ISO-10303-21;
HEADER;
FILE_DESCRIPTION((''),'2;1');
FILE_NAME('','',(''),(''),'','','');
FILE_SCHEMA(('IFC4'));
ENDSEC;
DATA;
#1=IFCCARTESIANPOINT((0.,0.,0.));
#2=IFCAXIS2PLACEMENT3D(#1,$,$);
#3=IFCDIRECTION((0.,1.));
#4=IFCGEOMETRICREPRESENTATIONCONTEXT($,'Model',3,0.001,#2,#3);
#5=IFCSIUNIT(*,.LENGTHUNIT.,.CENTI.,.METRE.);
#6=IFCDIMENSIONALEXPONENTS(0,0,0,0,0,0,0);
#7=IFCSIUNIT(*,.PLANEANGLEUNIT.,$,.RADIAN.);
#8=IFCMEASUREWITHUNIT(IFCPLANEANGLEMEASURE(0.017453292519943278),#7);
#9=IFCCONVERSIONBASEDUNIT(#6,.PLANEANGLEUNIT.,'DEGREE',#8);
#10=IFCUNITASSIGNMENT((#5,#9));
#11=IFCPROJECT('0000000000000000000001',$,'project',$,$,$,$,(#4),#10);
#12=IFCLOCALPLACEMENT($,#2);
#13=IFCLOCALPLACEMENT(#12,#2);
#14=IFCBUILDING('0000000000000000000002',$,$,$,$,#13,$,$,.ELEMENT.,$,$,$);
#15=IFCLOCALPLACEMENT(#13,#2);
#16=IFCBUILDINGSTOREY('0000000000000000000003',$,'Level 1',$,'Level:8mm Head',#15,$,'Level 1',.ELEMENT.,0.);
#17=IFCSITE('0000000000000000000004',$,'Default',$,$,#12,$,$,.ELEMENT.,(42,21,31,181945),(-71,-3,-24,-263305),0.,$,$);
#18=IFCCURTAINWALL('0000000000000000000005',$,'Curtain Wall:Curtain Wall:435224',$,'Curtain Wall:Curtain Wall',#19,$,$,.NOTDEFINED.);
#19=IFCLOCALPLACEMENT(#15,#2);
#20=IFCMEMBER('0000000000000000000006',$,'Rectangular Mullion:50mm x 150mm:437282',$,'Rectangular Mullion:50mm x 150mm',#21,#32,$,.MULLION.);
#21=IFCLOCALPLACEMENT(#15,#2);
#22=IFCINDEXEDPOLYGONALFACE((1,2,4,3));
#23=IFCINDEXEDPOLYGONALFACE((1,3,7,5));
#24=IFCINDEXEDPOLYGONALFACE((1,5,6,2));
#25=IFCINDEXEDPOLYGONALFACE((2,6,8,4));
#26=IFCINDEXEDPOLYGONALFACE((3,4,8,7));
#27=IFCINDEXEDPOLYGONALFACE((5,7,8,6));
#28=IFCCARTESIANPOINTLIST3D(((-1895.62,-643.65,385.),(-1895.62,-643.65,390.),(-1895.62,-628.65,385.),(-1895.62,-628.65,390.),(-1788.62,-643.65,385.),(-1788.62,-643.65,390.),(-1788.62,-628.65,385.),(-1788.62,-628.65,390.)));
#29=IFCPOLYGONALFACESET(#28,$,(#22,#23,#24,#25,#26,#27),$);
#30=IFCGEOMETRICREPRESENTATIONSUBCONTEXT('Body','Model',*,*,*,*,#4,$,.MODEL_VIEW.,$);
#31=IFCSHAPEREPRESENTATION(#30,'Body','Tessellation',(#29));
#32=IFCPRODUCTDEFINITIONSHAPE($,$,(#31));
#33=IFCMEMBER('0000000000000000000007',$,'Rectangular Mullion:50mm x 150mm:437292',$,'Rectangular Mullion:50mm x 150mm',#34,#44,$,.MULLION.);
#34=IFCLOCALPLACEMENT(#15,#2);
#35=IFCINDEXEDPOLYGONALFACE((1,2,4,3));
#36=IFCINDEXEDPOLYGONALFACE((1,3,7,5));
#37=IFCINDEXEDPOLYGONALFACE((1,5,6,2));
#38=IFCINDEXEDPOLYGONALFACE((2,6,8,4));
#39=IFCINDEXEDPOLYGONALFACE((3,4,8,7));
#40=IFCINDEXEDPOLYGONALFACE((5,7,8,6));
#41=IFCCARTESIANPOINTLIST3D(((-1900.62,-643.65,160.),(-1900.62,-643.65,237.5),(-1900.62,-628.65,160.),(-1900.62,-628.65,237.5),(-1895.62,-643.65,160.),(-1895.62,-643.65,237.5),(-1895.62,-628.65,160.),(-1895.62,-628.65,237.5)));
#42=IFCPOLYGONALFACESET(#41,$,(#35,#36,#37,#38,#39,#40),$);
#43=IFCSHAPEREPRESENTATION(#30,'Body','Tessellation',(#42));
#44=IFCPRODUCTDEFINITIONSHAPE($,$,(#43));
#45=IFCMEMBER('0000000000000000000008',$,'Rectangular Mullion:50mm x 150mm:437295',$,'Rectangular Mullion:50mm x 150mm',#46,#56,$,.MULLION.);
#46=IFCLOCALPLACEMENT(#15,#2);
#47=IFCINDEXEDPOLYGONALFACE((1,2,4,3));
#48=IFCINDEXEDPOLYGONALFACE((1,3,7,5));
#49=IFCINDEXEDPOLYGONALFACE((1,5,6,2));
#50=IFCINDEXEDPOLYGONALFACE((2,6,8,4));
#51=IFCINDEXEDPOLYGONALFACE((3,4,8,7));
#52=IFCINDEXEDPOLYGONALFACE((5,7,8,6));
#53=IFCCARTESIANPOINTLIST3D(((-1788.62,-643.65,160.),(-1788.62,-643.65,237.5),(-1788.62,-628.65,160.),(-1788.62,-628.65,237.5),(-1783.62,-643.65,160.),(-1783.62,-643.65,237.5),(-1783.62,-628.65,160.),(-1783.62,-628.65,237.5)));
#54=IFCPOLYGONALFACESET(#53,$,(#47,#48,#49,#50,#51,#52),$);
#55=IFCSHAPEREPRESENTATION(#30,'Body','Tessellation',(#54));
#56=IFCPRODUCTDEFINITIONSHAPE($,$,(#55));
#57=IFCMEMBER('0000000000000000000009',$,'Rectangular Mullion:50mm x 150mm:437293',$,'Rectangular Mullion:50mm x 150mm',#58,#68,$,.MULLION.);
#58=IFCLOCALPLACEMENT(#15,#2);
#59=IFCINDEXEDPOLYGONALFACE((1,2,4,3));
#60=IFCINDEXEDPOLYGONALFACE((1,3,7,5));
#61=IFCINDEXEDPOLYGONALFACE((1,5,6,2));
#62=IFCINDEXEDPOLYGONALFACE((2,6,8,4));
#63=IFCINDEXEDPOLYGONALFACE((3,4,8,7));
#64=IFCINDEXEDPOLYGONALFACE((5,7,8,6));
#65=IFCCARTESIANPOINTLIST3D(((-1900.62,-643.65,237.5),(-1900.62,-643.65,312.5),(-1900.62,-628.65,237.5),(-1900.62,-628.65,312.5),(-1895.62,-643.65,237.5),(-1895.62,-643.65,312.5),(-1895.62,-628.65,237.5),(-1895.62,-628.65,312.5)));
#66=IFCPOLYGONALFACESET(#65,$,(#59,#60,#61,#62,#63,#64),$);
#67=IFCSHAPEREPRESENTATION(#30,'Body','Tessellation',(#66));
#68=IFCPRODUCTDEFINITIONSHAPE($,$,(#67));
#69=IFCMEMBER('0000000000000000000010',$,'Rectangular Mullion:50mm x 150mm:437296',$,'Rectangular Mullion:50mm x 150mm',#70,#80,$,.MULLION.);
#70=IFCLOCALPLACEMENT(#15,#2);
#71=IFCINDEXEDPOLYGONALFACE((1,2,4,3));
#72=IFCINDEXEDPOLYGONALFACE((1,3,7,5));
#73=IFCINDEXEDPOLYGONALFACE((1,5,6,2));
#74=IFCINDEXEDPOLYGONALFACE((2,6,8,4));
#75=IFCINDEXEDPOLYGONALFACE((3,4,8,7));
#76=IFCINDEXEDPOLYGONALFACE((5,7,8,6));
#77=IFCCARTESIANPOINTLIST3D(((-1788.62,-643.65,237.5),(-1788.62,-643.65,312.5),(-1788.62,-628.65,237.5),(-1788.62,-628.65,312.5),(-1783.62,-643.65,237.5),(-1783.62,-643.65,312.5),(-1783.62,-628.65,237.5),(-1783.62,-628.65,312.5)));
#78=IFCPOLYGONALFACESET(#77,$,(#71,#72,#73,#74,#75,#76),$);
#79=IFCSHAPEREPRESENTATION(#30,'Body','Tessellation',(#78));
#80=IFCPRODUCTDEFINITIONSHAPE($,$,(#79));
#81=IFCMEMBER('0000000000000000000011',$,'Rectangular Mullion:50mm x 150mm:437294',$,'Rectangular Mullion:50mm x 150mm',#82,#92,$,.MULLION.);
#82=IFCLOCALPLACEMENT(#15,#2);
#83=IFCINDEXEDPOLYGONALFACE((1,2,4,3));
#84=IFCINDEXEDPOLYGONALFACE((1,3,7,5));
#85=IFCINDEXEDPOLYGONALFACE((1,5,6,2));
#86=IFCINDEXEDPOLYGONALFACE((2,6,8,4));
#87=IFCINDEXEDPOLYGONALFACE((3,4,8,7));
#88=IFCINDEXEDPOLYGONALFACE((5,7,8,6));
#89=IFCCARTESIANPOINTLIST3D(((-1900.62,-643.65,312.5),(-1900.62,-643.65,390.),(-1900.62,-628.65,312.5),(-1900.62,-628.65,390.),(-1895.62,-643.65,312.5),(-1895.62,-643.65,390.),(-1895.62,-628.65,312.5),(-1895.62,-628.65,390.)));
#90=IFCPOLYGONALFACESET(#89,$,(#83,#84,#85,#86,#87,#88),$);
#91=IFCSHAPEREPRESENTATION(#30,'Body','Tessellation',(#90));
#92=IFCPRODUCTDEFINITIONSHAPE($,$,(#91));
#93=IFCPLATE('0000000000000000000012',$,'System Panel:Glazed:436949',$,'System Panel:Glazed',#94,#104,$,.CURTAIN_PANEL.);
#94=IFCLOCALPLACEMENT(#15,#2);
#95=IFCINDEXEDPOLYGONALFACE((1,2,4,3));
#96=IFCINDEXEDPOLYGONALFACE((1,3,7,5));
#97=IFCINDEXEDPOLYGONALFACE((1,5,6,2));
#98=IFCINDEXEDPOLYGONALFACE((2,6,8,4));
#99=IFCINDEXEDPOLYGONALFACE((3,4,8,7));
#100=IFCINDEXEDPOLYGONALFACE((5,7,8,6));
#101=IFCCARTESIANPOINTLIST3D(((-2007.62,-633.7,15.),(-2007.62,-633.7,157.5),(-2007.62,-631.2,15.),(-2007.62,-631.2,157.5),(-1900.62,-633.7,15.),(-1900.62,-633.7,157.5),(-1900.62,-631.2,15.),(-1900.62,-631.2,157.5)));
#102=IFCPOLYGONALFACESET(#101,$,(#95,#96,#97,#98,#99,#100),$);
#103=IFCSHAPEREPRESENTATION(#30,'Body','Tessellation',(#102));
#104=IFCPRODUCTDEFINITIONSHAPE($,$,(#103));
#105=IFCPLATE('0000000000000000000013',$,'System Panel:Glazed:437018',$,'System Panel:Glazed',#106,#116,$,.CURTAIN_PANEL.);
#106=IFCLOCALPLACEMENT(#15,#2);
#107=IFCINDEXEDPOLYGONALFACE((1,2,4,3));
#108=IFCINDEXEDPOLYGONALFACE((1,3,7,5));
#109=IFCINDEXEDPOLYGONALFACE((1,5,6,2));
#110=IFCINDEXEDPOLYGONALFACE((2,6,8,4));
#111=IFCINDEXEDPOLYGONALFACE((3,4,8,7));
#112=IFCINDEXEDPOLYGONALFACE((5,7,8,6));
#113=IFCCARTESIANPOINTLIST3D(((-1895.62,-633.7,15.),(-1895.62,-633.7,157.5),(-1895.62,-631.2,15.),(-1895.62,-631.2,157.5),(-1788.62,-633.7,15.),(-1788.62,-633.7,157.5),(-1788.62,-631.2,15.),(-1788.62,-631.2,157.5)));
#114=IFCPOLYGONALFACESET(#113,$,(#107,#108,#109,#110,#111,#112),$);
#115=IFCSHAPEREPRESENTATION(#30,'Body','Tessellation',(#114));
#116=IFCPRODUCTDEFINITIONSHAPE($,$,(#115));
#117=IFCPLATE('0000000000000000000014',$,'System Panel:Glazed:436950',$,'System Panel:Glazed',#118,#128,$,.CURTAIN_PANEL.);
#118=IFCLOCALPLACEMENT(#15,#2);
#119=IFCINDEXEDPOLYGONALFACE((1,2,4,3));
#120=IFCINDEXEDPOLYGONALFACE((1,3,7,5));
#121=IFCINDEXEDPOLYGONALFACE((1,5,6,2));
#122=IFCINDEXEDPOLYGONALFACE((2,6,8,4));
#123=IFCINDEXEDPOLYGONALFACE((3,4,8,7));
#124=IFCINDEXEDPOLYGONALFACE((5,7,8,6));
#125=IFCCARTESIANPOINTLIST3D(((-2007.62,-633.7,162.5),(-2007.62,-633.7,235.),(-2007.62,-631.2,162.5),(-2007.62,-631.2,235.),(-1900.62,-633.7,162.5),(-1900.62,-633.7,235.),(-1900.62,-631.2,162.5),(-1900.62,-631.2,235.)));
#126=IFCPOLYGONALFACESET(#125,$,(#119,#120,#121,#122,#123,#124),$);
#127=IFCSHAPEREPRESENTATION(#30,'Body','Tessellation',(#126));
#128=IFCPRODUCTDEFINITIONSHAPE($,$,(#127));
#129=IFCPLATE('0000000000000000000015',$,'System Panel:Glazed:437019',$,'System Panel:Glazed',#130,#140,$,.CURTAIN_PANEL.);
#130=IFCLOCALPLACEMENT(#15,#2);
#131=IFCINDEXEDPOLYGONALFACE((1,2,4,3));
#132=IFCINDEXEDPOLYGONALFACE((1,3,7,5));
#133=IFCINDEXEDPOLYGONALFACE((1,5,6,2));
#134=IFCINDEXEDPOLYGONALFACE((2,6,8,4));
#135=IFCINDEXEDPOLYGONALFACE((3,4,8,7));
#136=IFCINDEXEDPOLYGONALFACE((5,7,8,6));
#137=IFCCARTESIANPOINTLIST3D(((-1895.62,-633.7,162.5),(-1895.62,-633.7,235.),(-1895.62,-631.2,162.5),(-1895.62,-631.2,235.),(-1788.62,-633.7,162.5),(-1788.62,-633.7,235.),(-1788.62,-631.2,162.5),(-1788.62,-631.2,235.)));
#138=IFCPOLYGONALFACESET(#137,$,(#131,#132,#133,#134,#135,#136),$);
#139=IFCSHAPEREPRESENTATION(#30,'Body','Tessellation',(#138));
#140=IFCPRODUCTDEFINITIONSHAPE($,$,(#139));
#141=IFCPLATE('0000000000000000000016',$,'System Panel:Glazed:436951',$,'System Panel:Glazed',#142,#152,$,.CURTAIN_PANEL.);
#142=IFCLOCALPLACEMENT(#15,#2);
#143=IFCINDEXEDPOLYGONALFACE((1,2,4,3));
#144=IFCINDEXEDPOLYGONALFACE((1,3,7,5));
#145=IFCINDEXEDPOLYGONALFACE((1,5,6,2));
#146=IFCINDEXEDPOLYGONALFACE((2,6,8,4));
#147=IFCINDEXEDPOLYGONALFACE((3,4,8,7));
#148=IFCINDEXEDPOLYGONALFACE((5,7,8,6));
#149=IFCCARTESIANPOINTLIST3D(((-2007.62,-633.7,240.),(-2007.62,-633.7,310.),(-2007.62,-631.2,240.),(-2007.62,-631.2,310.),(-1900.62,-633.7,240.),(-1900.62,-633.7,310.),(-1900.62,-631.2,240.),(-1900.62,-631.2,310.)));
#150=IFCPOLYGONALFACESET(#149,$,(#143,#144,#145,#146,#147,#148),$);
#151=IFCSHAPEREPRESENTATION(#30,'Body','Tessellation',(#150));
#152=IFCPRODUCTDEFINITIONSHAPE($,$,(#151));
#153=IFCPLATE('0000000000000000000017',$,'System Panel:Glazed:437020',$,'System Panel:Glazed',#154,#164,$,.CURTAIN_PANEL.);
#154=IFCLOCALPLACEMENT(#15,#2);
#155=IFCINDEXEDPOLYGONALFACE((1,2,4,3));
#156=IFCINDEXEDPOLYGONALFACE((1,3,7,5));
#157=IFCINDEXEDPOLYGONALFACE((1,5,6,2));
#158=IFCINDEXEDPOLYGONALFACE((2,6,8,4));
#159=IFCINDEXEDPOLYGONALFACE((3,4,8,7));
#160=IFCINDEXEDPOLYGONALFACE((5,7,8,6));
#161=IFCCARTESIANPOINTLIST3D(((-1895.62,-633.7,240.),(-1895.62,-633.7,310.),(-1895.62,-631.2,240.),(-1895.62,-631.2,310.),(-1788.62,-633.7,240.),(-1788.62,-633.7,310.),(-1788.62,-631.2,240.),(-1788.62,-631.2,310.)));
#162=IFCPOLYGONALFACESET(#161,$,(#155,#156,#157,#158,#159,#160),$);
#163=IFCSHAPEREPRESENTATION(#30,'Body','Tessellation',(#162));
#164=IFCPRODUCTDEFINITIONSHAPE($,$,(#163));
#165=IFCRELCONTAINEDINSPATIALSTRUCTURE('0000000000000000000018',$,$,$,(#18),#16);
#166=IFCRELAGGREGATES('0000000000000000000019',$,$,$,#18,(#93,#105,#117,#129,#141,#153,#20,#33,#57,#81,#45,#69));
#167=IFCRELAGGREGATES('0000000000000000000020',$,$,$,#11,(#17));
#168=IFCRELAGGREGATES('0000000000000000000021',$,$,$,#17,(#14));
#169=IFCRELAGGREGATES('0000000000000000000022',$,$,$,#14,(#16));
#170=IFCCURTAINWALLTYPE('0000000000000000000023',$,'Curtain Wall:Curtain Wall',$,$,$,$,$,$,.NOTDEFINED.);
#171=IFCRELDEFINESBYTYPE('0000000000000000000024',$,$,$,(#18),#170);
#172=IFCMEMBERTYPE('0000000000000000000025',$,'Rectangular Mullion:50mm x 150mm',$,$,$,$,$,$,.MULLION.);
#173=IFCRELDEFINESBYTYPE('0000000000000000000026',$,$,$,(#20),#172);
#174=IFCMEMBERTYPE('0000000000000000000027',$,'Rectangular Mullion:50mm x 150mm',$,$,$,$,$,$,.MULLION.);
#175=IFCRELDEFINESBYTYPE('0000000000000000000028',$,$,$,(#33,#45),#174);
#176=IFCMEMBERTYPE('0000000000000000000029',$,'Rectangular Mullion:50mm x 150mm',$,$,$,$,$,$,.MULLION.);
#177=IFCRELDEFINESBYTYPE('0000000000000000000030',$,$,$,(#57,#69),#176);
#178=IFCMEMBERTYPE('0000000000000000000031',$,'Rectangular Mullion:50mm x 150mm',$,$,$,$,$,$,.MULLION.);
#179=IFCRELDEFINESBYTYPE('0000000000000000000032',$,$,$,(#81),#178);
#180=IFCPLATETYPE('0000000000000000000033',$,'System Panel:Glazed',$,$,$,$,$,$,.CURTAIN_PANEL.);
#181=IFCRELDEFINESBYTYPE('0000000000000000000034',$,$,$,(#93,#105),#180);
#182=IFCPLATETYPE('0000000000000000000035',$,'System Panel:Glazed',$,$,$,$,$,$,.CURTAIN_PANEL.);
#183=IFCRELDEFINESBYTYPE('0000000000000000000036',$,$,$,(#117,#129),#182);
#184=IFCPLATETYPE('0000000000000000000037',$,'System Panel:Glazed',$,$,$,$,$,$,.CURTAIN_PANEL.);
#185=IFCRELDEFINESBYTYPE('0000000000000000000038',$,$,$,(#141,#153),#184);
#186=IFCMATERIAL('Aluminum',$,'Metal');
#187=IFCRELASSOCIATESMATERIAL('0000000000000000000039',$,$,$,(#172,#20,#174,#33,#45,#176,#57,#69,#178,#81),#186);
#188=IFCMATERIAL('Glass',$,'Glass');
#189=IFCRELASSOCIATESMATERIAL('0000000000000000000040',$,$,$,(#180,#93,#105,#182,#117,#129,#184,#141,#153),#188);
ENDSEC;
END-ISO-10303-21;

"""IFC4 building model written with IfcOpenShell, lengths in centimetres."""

from ifc_helpers import new_model, entity, si_unit, converted_unit, direction, frame, origin, place, context, subcontext, project, spatial, indexed_curve, outline, extrude, source, transform, mapped, material, type_object, type_shapes, element, aggregate, save


model = new_model("IFC4")

# Units and contexts
model_context = context("Model", 3, precision=0.001, world=origin(), true_north=direction((0.0, 1.0)))
body_context = subcontext(model_context, "Body", "Model", "MODEL_VIEW")
ifc_project = project(units=[si_unit("LENGTHUNIT", "METRE", prefix="CENTI"), converted_unit("PLANEANGLEUNIT", "DEGREE", entity("IfcPlaneAngleMeasure", 0.017453292519943278), si_unit("PLANEANGLEUNIT", "RADIAN"), dimensions=[0, 0, 0, 0, 0, 0, 0])], contexts=[model_context])

# Site, building, storey
site_placement = place(None, origin())
site = spatial("IfcSite", under=ifc_project, at=site_placement, Name="Default", CompositionType="ELEMENT", RefLatitude=(42, 21, 31, 181945), RefLongitude=(-71, -3, -24, -263305), RefElevation=0.0)
building_placement = place(site_placement, origin())
building = spatial("IfcBuilding", under=site, at=building_placement, CompositionType="ELEMENT")
storey_placement = place(building_placement, origin())
storey = spatial("IfcBuildingStorey", under=building, at=storey_placement, Name="Level 1", ObjectType="Level:8mm Head", LongName="Level 1", CompositionType="ELEMENT", Elevation=0.0)

# Curtain wall, members, plates
curtain_wall_type = type_object("IfcCurtainWallType", Name="Curtain Wall:Curtain Wall", PredefinedType="NOTDEFINED")
curtain_wall_placement = place(storey_placement, origin())
curtain_wall = element("IfcCurtainWall", 1, at=curtain_wall_placement, inside=storey, type_object=curtain_wall_type, Name="Curtain Wall:Curtain Wall:435224", ObjectType="Curtain Wall:Curtain Wall", PredefinedType="NOTDEFINED")
ifc_material_1 = material(Name="Aluminum", Category="Metal")
member_type_1 = type_object("IfcMemberType", Name="Rectangular Mullion:50mm x 150mm", PredefinedType="MULLION", material=ifc_material_1)
shared_shape_1 = source(origin(), body_context, "Body", "SweptSolid", [
    extrude(outline(indexed_curve([(-2.5, -7.5), (2.5, -7.5), (2.5, 7.5), (-2.5, 7.5), (-2.5, -7.5)], self_intersect=False)), frame((-2.5, 0.0, -107.0), z_axis=(0.0, 0.0, 1.0), x_axis=(-1.0, 0.0, 0.0)), (0.0, 0.0, 1.0), 107.0),
])
type_shapes(member_type_1, [shared_shape_1])
member_1_placement = place(curtain_wall_placement, frame((-1788.62, -636.15, 390.0), z_axis=(1.0, 0.0, 0.0), x_axis=(0.0, 0.0, 1.0)))
member_1 = element("IfcMember", 2, at=member_1_placement, type_object=member_type_1, material=ifc_material_1, Name="Rectangular Mullion:50mm x 150mm:437282", ObjectType="Rectangular Mullion:50mm x 150mm", PredefinedType="MULLION", context=body_context, shape_type="MappedRepresentation", body=[
    mapped(shared_shape_1, transform((0.0, 0.0, 0.0), scale=1.0)),
])
member_type_2 = type_object("IfcMemberType", Name="Rectangular Mullion:50mm x 150mm", PredefinedType="MULLION", material=ifc_material_1)
shared_shape_2 = source(origin(), body_context, "Body", "SweptSolid", [
    extrude(outline(indexed_curve([(-2.5, -7.5), (2.5, -7.5), (2.5, 7.5), (-2.5, 7.5), (-2.5, -7.5)], self_intersect=False)), frame((0.0, 0.0, -77.5), z_axis=(0.0, 0.0, 1.0), x_axis=(-1.0, 0.0, 0.0)), (0.0, 0.0, 1.0), 77.5),
])
type_shapes(member_type_2, [shared_shape_2])
member_2_placement = place(curtain_wall_placement, frame((-1898.12, -636.15, 160.0), z_axis=(0.0, 0.0, -1.0), x_axis=(1.0, 0.0, 0.0)))
member_2 = element("IfcMember", 3, at=member_2_placement, type_object=member_type_2, material=ifc_material_1, Name="Rectangular Mullion:50mm x 150mm:437292", ObjectType="Rectangular Mullion:50mm x 150mm", PredefinedType="MULLION", context=body_context, shape_type="MappedRepresentation", body=[
    mapped(shared_shape_2, transform((0.0, 0.0, 0.0), scale=1.0)),
])
member_3_placement = place(curtain_wall_placement, frame((-1786.12, -636.15, 160.0), z_axis=(0.0, 0.0, -1.0), x_axis=(1.0, 0.0, 0.0)))
member_3 = element("IfcMember", 4, at=member_3_placement, type_object=member_type_2, material=ifc_material_1, Name="Rectangular Mullion:50mm x 150mm:437295", ObjectType="Rectangular Mullion:50mm x 150mm", PredefinedType="MULLION", context=body_context, shape_type="MappedRepresentation", body=[
    mapped(shared_shape_2, transform((0.0, 0.0, 0.0), scale=1.0)),
])
member_type_3 = type_object("IfcMemberType", Name="Rectangular Mullion:50mm x 150mm", PredefinedType="MULLION", material=ifc_material_1)
shared_shape_3 = source(origin(), body_context, "Body", "SweptSolid", [
    extrude(outline(indexed_curve([(-2.5, -7.5), (2.5, -7.5), (2.5, 7.5), (-2.5, 7.5), (-2.5, -7.5)], self_intersect=False)), frame((0.0, 0.0, -75.0), z_axis=(0.0, 0.0, 1.0), x_axis=(-1.0, 0.0, 0.0)), (0.0, 0.0, 1.0), 75.0),
])
type_shapes(member_type_3, [shared_shape_3])
member_4_placement = place(curtain_wall_placement, frame((-1898.12, -636.15, 237.5), z_axis=(0.0, 0.0, -1.0), x_axis=(1.0, 0.0, 0.0)))
member_4 = element("IfcMember", 5, at=member_4_placement, type_object=member_type_3, material=ifc_material_1, Name="Rectangular Mullion:50mm x 150mm:437293", ObjectType="Rectangular Mullion:50mm x 150mm", PredefinedType="MULLION", context=body_context, shape_type="MappedRepresentation", body=[
    mapped(shared_shape_3, transform((0.0, 0.0, 0.0), scale=1.0)),
])
member_5_placement = place(curtain_wall_placement, frame((-1786.12, -636.15, 237.5), z_axis=(0.0, 0.0, -1.0), x_axis=(1.0, 0.0, 0.0)))
member_5 = element("IfcMember", 6, at=member_5_placement, type_object=member_type_3, material=ifc_material_1, Name="Rectangular Mullion:50mm x 150mm:437296", ObjectType="Rectangular Mullion:50mm x 150mm", PredefinedType="MULLION", context=body_context, shape_type="MappedRepresentation", body=[
    mapped(shared_shape_3, transform((0.0, 0.0, 0.0), scale=1.0)),
])
member_type_4 = type_object("IfcMemberType", Name="Rectangular Mullion:50mm x 150mm", PredefinedType="MULLION", material=ifc_material_1)
shared_shape_4 = source(origin(), body_context, "Body", "SweptSolid", [
    extrude(outline(indexed_curve([(-2.5, -7.5), (2.5, -7.5), (2.5, 7.5), (-2.5, 7.5), (-2.5, -7.5)], self_intersect=False)), frame((0.0, 0.0, -77.5), z_axis=(0.0, 0.0, 1.0), x_axis=(-1.0, 0.0, 0.0)), (0.0, 0.0, 1.0), 77.5),
])
type_shapes(member_type_4, [shared_shape_4])
member_6_placement = place(curtain_wall_placement, frame((-1898.12, -636.15, 312.5), z_axis=(0.0, 0.0, -1.0), x_axis=(1.0, 0.0, 0.0)))
member_6 = element("IfcMember", 7, at=member_6_placement, type_object=member_type_4, material=ifc_material_1, Name="Rectangular Mullion:50mm x 150mm:437294", ObjectType="Rectangular Mullion:50mm x 150mm", PredefinedType="MULLION", context=body_context, shape_type="MappedRepresentation", body=[
    mapped(shared_shape_4, transform((0.0, 0.0, 0.0), scale=1.0)),
])
ifc_material_2 = material(Name="Glass", Category="Glass")
plate_type_1 = type_object("IfcPlateType", Name="System Panel:Glazed", PredefinedType="CURTAIN_PANEL", material=ifc_material_2)
shared_shape_5 = source(origin(), body_context, "Body", "SweptSolid", [
    extrude(outline(indexed_curve([(-1.25, -53.5), (1.25, -53.5), (1.25, 53.5), (-1.25, 53.5), (-1.25, -53.5)], self_intersect=False)), frame((0.0, 3.7, 0.0), z_axis=(0.0, 0.0, 1.0), x_axis=(0.0, 1.0, 0.0)), (0.0, 0.0, 1.0), 142.5),
])
type_shapes(plate_type_1, [shared_shape_5])
plate_1_placement = place(curtain_wall_placement, frame((-1954.12, -636.15, 15.0)))
plate_1 = element("IfcPlate", 8, at=plate_1_placement, type_object=plate_type_1, material=ifc_material_2, Name="System Panel:Glazed:436949", ObjectType="System Panel:Glazed", PredefinedType="CURTAIN_PANEL", context=body_context, shape_type="MappedRepresentation", body=[
    mapped(shared_shape_5, transform((0.0, 0.0, 0.0), scale=1.0)),
])
plate_2_placement = place(curtain_wall_placement, frame((-1842.12, -636.15, 15.0)))
plate_2 = element("IfcPlate", 9, at=plate_2_placement, type_object=plate_type_1, material=ifc_material_2, Name="System Panel:Glazed:437018", ObjectType="System Panel:Glazed", PredefinedType="CURTAIN_PANEL", context=body_context, shape_type="MappedRepresentation", body=[
    mapped(shared_shape_5, transform((0.0, 0.0, 0.0), scale=1.0)),
])
plate_type_2 = type_object("IfcPlateType", Name="System Panel:Glazed", PredefinedType="CURTAIN_PANEL", material=ifc_material_2)
shared_shape_6 = source(origin(), body_context, "Body", "SweptSolid", [
    extrude(outline(indexed_curve([(-1.25, -53.5), (1.25, -53.5), (1.25, 53.5), (-1.25, 53.5), (-1.25, -53.5)], self_intersect=False)), frame((0.0, 3.7, 0.0), z_axis=(0.0, 0.0, 1.0), x_axis=(0.0, 1.0, 0.0)), (0.0, 0.0, 1.0), 72.5),
])
type_shapes(plate_type_2, [shared_shape_6])
plate_3_placement = place(curtain_wall_placement, frame((-1954.12, -636.15, 162.5)))
plate_3 = element("IfcPlate", 10, at=plate_3_placement, type_object=plate_type_2, material=ifc_material_2, Name="System Panel:Glazed:436950", ObjectType="System Panel:Glazed", PredefinedType="CURTAIN_PANEL", context=body_context, shape_type="MappedRepresentation", body=[
    mapped(shared_shape_6, transform((0.0, 0.0, 0.0), scale=1.0)),
])
plate_4_placement = place(curtain_wall_placement, frame((-1842.12, -636.15, 162.5)))
plate_4 = element("IfcPlate", 11, at=plate_4_placement, type_object=plate_type_2, material=ifc_material_2, Name="System Panel:Glazed:437019", ObjectType="System Panel:Glazed", PredefinedType="CURTAIN_PANEL", context=body_context, shape_type="MappedRepresentation", body=[
    mapped(shared_shape_6, transform((0.0, 0.0, 0.0), scale=1.0)),
])
plate_type_3 = type_object("IfcPlateType", Name="System Panel:Glazed", PredefinedType="CURTAIN_PANEL", material=ifc_material_2)
shared_shape_7 = source(origin(), body_context, "Body", "SweptSolid", [
    extrude(outline(indexed_curve([(-1.25, -53.5), (1.25, -53.5), (1.25, 53.5), (-1.25, 53.5), (-1.25, -53.5)], self_intersect=False)), frame((0.0, 3.7, 0.0), z_axis=(0.0, 0.0, 1.0), x_axis=(0.0, 1.0, 0.0)), (0.0, 0.0, 1.0), 70.0),
])
type_shapes(plate_type_3, [shared_shape_7])
plate_5_placement = place(curtain_wall_placement, frame((-1954.12, -636.15, 240.0)))
plate_5 = element("IfcPlate", 12, at=plate_5_placement, type_object=plate_type_3, material=ifc_material_2, Name="System Panel:Glazed:436951", ObjectType="System Panel:Glazed", PredefinedType="CURTAIN_PANEL", context=body_context, shape_type="MappedRepresentation", body=[
    mapped(shared_shape_7, transform((0.0, 0.0, 0.0), scale=1.0)),
])
plate_6_placement = place(curtain_wall_placement, frame((-1842.12, -636.15, 240.0)))
plate_6 = element("IfcPlate", 13, at=plate_6_placement, type_object=plate_type_3, material=ifc_material_2, Name="System Panel:Glazed:437020", ObjectType="System Panel:Glazed", PredefinedType="CURTAIN_PANEL", context=body_context, shape_type="MappedRepresentation", body=[
    mapped(shared_shape_7, transform((0.0, 0.0, 0.0), scale=1.0)),
])
aggregate(curtain_wall, [plate_1, plate_2, plate_3, plate_4, plate_5, plate_6, member_1, member_2, member_4, member_6, member_3, member_5])

save(model, "model.ifc")
